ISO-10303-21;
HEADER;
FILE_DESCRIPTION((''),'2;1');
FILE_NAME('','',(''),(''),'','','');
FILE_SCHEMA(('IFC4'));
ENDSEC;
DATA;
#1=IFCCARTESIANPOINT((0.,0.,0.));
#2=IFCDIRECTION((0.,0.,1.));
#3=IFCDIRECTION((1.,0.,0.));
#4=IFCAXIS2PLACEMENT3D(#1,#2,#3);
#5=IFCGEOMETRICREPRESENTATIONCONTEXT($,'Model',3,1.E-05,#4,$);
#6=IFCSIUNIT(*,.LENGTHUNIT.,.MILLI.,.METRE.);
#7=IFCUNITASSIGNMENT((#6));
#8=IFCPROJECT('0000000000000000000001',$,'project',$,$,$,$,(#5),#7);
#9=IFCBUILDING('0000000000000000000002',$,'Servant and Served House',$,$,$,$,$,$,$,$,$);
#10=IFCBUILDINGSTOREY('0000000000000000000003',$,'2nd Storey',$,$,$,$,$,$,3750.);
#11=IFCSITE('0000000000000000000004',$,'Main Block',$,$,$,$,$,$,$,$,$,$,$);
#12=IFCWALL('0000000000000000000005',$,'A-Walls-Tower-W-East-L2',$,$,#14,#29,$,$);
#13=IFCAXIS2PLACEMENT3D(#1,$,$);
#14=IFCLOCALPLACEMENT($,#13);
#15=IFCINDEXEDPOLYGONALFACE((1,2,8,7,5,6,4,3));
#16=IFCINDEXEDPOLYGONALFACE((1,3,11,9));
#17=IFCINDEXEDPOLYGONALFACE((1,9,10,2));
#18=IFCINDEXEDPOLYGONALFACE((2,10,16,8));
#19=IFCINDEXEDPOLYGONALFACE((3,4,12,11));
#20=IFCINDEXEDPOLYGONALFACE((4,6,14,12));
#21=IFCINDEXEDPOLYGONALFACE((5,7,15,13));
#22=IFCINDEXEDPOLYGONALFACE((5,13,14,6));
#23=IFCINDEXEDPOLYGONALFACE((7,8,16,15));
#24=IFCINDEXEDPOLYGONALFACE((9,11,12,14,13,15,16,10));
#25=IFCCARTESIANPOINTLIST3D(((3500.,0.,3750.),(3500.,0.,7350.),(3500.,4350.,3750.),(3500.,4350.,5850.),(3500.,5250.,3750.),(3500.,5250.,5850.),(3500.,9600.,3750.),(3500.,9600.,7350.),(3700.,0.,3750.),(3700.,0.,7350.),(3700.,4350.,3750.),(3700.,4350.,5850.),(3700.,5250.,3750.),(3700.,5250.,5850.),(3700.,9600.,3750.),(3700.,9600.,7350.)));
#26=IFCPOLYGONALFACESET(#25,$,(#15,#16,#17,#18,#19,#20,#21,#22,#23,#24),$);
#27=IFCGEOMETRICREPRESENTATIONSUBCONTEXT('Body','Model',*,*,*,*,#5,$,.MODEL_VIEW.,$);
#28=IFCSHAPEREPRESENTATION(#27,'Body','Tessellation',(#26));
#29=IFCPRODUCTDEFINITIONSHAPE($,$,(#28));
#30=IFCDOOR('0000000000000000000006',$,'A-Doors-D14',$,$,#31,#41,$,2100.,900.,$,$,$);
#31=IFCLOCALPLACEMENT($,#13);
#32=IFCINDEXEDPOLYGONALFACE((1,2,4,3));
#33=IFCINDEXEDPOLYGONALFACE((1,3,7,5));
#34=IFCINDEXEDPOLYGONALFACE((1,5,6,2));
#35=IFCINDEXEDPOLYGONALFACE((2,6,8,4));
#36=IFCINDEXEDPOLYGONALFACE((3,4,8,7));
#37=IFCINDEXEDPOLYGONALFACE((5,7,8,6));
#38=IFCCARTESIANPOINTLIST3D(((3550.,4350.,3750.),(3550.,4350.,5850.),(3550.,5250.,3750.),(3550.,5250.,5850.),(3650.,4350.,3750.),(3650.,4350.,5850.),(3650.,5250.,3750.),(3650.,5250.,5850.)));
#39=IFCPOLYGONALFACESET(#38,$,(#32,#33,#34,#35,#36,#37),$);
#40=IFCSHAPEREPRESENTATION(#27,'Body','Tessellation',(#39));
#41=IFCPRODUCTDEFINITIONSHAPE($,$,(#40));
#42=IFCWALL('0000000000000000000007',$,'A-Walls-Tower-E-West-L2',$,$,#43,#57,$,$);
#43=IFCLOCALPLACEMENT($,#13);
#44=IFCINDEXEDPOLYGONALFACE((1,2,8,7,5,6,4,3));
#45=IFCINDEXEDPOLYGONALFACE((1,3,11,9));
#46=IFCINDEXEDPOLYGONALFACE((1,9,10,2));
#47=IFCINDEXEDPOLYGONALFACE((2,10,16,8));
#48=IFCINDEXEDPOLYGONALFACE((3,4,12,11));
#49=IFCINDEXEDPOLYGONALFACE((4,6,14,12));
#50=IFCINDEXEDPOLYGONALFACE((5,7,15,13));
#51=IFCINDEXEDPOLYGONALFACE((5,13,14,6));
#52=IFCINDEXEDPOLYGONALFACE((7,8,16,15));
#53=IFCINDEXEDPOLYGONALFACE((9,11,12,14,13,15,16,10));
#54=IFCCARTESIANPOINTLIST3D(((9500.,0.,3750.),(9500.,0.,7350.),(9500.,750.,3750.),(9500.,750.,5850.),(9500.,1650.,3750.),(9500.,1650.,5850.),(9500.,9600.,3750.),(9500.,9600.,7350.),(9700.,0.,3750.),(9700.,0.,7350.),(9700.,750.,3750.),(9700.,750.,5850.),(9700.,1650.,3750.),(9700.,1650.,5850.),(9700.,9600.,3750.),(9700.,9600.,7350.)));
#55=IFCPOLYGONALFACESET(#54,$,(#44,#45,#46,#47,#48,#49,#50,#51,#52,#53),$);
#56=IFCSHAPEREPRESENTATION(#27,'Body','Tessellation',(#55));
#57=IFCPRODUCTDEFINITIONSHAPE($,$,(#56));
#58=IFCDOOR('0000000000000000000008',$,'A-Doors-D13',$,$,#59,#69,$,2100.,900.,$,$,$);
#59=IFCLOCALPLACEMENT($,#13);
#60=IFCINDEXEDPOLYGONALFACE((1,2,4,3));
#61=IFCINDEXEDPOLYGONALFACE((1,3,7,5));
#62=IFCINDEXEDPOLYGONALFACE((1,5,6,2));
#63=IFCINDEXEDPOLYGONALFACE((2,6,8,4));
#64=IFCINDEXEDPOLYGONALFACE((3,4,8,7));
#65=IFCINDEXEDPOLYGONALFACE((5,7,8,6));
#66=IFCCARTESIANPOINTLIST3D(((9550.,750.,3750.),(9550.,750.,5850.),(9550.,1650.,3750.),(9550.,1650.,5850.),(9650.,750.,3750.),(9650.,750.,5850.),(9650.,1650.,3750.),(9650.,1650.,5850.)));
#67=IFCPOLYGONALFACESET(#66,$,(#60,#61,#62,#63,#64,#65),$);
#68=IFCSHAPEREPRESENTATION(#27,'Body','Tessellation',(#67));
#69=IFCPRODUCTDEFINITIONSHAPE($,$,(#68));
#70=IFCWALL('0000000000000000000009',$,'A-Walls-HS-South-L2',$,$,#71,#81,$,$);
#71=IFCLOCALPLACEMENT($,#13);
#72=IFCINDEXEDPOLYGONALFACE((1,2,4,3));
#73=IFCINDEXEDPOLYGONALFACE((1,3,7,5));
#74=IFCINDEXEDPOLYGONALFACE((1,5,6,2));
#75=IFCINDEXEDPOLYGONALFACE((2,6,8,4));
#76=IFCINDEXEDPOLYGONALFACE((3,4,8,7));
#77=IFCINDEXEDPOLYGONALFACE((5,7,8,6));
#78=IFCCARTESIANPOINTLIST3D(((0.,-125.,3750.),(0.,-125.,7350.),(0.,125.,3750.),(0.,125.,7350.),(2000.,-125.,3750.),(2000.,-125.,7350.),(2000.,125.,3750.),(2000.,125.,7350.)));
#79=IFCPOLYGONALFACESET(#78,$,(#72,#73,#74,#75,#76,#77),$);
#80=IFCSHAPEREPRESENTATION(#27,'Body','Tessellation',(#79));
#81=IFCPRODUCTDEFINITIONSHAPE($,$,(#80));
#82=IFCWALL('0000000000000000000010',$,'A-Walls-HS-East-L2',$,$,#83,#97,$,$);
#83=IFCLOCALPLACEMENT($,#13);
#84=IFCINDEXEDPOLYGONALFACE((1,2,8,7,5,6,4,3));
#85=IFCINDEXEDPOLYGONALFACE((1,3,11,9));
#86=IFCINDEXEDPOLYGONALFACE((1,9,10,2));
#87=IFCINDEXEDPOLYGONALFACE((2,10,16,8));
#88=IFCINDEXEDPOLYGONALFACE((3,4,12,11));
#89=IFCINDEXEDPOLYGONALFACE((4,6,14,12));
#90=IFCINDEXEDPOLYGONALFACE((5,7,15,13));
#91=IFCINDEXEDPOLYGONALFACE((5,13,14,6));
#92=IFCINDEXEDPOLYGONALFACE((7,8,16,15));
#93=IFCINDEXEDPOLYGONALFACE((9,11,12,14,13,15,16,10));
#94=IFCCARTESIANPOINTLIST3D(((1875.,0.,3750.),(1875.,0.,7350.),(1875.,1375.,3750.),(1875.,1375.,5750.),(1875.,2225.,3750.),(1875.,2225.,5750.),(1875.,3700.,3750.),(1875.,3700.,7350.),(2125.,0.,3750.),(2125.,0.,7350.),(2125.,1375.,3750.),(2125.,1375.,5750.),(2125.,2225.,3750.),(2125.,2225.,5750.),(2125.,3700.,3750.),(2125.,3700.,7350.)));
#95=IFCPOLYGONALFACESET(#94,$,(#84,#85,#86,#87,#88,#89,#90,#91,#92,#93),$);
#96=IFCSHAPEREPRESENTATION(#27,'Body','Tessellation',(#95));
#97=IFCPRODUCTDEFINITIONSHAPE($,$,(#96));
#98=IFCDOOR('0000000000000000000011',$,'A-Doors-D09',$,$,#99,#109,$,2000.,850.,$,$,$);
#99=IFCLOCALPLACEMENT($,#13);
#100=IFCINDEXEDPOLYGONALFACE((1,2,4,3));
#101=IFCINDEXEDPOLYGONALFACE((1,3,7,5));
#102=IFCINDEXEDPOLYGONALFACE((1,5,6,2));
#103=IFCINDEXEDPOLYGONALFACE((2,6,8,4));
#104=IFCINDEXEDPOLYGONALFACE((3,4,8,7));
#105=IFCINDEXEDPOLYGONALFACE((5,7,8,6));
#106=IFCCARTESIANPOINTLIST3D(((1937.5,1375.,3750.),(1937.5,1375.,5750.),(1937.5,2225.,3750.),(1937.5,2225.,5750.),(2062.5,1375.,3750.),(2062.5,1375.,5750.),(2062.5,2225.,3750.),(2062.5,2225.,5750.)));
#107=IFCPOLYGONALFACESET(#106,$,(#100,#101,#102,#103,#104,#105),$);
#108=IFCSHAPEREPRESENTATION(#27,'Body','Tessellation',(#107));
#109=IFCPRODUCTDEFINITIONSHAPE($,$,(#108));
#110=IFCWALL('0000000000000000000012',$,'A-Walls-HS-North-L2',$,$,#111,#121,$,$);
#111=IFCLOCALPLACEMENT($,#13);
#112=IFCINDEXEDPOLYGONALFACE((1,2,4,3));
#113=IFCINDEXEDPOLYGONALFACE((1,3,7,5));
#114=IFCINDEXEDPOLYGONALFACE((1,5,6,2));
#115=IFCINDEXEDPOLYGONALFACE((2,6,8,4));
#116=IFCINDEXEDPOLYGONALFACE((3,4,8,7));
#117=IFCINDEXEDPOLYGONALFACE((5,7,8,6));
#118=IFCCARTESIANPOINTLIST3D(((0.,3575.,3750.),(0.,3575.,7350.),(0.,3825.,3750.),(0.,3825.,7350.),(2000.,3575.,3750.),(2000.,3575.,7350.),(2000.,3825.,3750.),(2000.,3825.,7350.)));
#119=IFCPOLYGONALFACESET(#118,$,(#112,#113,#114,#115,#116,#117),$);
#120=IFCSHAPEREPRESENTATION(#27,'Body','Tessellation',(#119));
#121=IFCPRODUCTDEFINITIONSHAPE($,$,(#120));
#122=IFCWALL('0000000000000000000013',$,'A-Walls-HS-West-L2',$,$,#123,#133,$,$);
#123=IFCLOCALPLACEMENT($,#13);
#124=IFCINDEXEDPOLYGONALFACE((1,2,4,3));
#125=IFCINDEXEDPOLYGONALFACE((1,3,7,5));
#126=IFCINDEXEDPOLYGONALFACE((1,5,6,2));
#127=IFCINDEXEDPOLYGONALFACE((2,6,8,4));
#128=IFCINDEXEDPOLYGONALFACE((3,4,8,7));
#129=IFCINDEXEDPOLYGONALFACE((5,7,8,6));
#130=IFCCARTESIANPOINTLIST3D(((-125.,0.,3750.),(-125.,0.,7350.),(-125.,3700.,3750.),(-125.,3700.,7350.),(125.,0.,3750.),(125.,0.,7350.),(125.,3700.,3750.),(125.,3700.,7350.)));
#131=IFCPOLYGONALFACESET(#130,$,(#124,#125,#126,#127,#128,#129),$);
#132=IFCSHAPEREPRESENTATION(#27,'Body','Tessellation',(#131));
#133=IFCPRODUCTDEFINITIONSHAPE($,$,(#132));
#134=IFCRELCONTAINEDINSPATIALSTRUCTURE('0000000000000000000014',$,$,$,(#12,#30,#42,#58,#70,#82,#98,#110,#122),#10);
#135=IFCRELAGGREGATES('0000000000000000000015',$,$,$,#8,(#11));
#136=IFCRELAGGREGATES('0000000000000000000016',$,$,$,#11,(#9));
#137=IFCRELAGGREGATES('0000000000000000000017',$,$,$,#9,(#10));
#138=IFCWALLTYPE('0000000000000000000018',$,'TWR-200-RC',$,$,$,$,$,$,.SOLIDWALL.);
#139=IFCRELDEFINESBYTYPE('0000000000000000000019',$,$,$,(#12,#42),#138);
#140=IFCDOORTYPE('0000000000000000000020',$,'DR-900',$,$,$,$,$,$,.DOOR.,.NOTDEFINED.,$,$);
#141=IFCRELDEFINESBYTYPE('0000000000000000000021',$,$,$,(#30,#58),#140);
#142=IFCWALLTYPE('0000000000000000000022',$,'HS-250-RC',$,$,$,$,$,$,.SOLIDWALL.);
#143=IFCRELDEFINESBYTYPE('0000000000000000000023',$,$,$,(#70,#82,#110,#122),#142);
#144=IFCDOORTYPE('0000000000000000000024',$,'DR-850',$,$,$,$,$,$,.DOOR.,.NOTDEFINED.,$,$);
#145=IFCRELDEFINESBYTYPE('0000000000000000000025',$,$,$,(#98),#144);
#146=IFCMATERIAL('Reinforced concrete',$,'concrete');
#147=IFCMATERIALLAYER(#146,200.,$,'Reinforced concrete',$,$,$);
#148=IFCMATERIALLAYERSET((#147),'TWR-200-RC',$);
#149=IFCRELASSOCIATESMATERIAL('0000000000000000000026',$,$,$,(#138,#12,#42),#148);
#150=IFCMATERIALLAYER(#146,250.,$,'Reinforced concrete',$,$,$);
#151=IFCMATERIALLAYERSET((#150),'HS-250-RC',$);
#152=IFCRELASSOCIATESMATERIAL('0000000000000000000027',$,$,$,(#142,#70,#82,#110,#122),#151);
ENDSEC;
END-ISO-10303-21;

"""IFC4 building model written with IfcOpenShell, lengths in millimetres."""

from ifc_helpers import new_model, si_unit, frame, origin_with_axes, place, context, subcontext, project, spatial, indexed_curve, outline, extrude, material, layer, layer_set, layer_usage, type_object, element, fill, save


model = new_model("IFC4")

# Units and contexts
model_context = context("Model", 3, precision=1e-05, world=origin_with_axes())
body_context = subcontext(model_context, "Body", "Model", "MODEL_VIEW")
ifc_project = project(units=[si_unit("LENGTHUNIT", "METRE", prefix="MILLI")], contexts=[model_context])

# Site, building, storey
site = spatial("IfcSite", under=ifc_project, Name="Main Block")
building = spatial("IfcBuilding", under=site, Name="Servant and Served House")
storey = spatial("IfcBuildingStorey", under=building, Name="2nd Storey", Elevation=3750.0)

# Shared definitions
ifc_material_1 = material(Name="Reinforced concrete", Category="concrete")

# Walls, openings, doors
door_type_1 = type_object("IfcDoorType", Name="DR-900", OperationType="NOTDEFINED", PredefinedType="DOOR")
ifc_layer_1 = layer(ifc_material_1, 200.0, Name="Reinforced concrete")
ifc_layer_set_1 = layer_set([ifc_layer_1], Name="TWR-200-RC")
ifc_layer_usage_1 = layer_usage(ifc_layer_set_1, "AXIS2", "POSITIVE", 0.0)
wall_type_1 = type_object("IfcWallType", Name="TWR-200-RC", PredefinedType="SOLIDWALL", material=ifc_layer_set_1)
wall_1_placement = place(None, frame((3700.0, 0.0, 3750.0), z_axis=(0.0, 0.0, 1.0), x_axis=(0.0, 1.0, 0.0)))
wall_1 = element("IfcWall", 1, at=wall_1_placement, inside=storey, type_object=wall_type_1, material=ifc_layer_usage_1, Name="A-Walls-Tower-W-East-L2", context=body_context, shape_type="SweptSolid", body=[
    extrude(outline(indexed_curve([(0.0, 0.0), (0.0, 200.0), (9600.0, 200.0), (9600.0, 0.0), (0.0, 0.0)], self_intersect=False)), origin_with_axes(), (0.0, 0.0, 1.0), 3600.0),
])
opening_1_placement = place(wall_1_placement, frame((4800.0, 100.0, 0.0), z_axis=(0.0, 0.0, 1.0), x_axis=(1.0, 0.0, 0.0)))
opening_1 = element("IfcOpeningElement", 2, at=opening_1_placement, cuts=wall_1, PredefinedType="OPENING", context=body_context, shape_type="SweptSolid", body=[
    extrude(outline(indexed_curve([(-450.0, -150.0), (450.0, -150.0), (450.0, 150.0), (-450.0, 150.0)])), None, (0.0, 0.0, 1.0), 2100.0),
])
door_1_placement = place(None, frame((3600.0, 4800.0, 3750.0), z_axis=(0.0, 0.0, 1.0), x_axis=(0.0, 1.0, 0.0)))
door_1 = element("IfcDoor", 3, at=door_1_placement, inside=storey, type_object=door_type_1, Name="A-Doors-D14", OverallHeight=2100.0, OverallWidth=900.0, context=body_context, shape_type="SweptSolid", body=[
    extrude(outline(indexed_curve([(-450.0, -50.0), (450.0, -50.0), (450.0, 50.0), (-450.0, 50.0)])), None, (0.0, 0.0, 1.0), 2100.0),
])
fill(opening_1, door_1)
ifc_layer_usage_2 = layer_usage(ifc_layer_set_1, "AXIS2", "POSITIVE", 0.0)
wall_2_placement = place(None, frame((9700.0, 0.0, 3750.0), z_axis=(0.0, 0.0, 1.0), x_axis=(0.0, 1.0, 0.0)))
wall_2 = element("IfcWall", 4, at=wall_2_placement, inside=storey, type_object=wall_type_1, material=ifc_layer_usage_2, Name="A-Walls-Tower-E-West-L2", context=body_context, shape_type="SweptSolid", body=[
    extrude(outline(indexed_curve([(0.0, 0.0), (0.0, 200.0), (9600.0, 200.0), (9600.0, 0.0), (0.0, 0.0)], self_intersect=False)), origin_with_axes(), (0.0, 0.0, 1.0), 3600.0),
])
opening_2_placement = place(wall_2_placement, frame((1200.0, 100.0, 0.0), z_axis=(0.0, 0.0, 1.0), x_axis=(1.0, 0.0, 0.0)))
opening_2 = element("IfcOpeningElement", 5, at=opening_2_placement, cuts=wall_2, PredefinedType="OPENING", context=body_context, shape_type="SweptSolid", body=[
    extrude(outline(indexed_curve([(-450.0, -150.0), (450.0, -150.0), (450.0, 150.0), (-450.0, 150.0)])), None, (0.0, 0.0, 1.0), 2100.0),
])
door_2_placement = place(None, frame((9600.0, 1200.0, 3750.0), z_axis=(0.0, 0.0, 1.0), x_axis=(0.0, 1.0, 0.0)))
door_2 = element("IfcDoor", 6, at=door_2_placement, inside=storey, type_object=door_type_1, Name="A-Doors-D13", OverallHeight=2100.0, OverallWidth=900.0, context=body_context, shape_type="SweptSolid", body=[
    extrude(outline(indexed_curve([(-450.0, -50.0), (450.0, -50.0), (450.0, 50.0), (-450.0, 50.0)])), None, (0.0, 0.0, 1.0), 2100.0),
])
fill(opening_2, door_2)

# Wall
ifc_layer_2 = layer(ifc_material_1, 250.0, Name="Reinforced concrete")
ifc_layer_set_2 = layer_set([ifc_layer_2], Name="HS-250-RC")
ifc_layer_usage_3 = layer_usage(ifc_layer_set_2, "AXIS2", "POSITIVE", 0.0)
wall_type_2 = type_object("IfcWallType", Name="HS-250-RC", PredefinedType="SOLIDWALL", material=ifc_layer_set_2)
wall_3_placement = place(None, frame((0.0, -125.0, 3750.0), z_axis=(0.0, 0.0, 1.0), x_axis=(1.0, 0.0, 0.0)))
element("IfcWall", 7, at=wall_3_placement, inside=storey, type_object=wall_type_2, material=ifc_layer_usage_3, Name="A-Walls-HS-South-L2", context=body_context, shape_type="SweptSolid", body=[
    extrude(outline(indexed_curve([(0.0, 0.0), (0.0, 250.0), (2000.0, 250.0), (2000.0, 0.0), (0.0, 0.0)], self_intersect=False)), origin_with_axes(), (0.0, 0.0, 1.0), 3600.0),
])

# Wall, opening, door
ifc_layer_usage_4 = layer_usage(ifc_layer_set_2, "AXIS2", "POSITIVE", 0.0)
wall_4_placement = place(None, frame((2125.0, 0.0, 3750.0), z_axis=(0.0, 0.0, 1.0), x_axis=(0.0, 1.0, 0.0)))
wall_4 = element("IfcWall", 8, at=wall_4_placement, inside=storey, type_object=wall_type_2, material=ifc_layer_usage_4, Name="A-Walls-HS-East-L2", context=body_context, shape_type="SweptSolid", body=[
    extrude(outline(indexed_curve([(0.0, 0.0), (0.0, 250.0), (3700.0, 250.0), (3700.0, 0.0), (0.0, 0.0)], self_intersect=False)), origin_with_axes(), (0.0, 0.0, 1.0), 3600.0),
])
opening_3_placement = place(wall_4_placement, frame((1800.0, 125.0, 0.0), z_axis=(0.0, 0.0, 1.0), x_axis=(1.0, 0.0, 0.0)))
opening_3 = element("IfcOpeningElement", 9, at=opening_3_placement, cuts=wall_4, PredefinedType="OPENING", context=body_context, shape_type="SweptSolid", body=[
    extrude(outline(indexed_curve([(-425.0, -175.0), (425.0, -175.0), (425.0, 175.0), (-425.0, 175.0)])), None, (0.0, 0.0, 1.0), 2000.0),
])
door_type_2 = type_object("IfcDoorType", Name="DR-850", OperationType="NOTDEFINED", PredefinedType="DOOR")
door_3_placement = place(None, frame((2000.0, 1800.0, 3750.0), z_axis=(0.0, 0.0, 1.0), x_axis=(0.0, 1.0, 0.0)))
door_3 = element("IfcDoor", 10, at=door_3_placement, inside=storey, type_object=door_type_2, Name="A-Doors-D09", OverallHeight=2000.0, OverallWidth=850.0, context=body_context, shape_type="SweptSolid", body=[
    extrude(outline(indexed_curve([(-425.0, -62.5), (425.0, -62.5), (425.0, 62.5), (-425.0, 62.5)])), None, (0.0, 0.0, 1.0), 2000.0),
])
fill(opening_3, door_3)

# Walls
ifc_layer_usage_5 = layer_usage(ifc_layer_set_2, "AXIS2", "POSITIVE", 0.0)
wall_5_placement = place(None, frame((2000.0, 3825.0, 3750.0), z_axis=(0.0, 0.0, 1.0), x_axis=(-1.0, 0.0, 0.0)))
element("IfcWall", 11, at=wall_5_placement, inside=storey, type_object=wall_type_2, material=ifc_layer_usage_5, Name="A-Walls-HS-North-L2", context=body_context, shape_type="SweptSolid", body=[
    extrude(outline(indexed_curve([(0.0, 0.0), (0.0, 250.0), (2000.0, 250.0), (2000.0, 0.0), (0.0, 0.0)], self_intersect=False)), origin_with_axes(), (0.0, 0.0, 1.0), 3600.0),
])
ifc_layer_usage_6 = layer_usage(ifc_layer_set_2, "AXIS2", "POSITIVE", 0.0)
wall_6_placement = place(None, frame((-125.0, 3700.0, 3750.0), z_axis=(0.0, 0.0, 1.0), x_axis=(0.0, -1.0, 0.0)))
element("IfcWall", 12, at=wall_6_placement, inside=storey, type_object=wall_type_2, material=ifc_layer_usage_6, Name="A-Walls-HS-West-L2", context=body_context, shape_type="SweptSolid", body=[
    extrude(outline(indexed_curve([(0.0, 0.0), (0.0, 250.0), (3700.0, 250.0), (3700.0, 0.0), (0.0, 0.0)], self_intersect=False)), origin_with_axes(), (0.0, 0.0, 1.0), 3600.0),
])

save(model, "model.ifc")
